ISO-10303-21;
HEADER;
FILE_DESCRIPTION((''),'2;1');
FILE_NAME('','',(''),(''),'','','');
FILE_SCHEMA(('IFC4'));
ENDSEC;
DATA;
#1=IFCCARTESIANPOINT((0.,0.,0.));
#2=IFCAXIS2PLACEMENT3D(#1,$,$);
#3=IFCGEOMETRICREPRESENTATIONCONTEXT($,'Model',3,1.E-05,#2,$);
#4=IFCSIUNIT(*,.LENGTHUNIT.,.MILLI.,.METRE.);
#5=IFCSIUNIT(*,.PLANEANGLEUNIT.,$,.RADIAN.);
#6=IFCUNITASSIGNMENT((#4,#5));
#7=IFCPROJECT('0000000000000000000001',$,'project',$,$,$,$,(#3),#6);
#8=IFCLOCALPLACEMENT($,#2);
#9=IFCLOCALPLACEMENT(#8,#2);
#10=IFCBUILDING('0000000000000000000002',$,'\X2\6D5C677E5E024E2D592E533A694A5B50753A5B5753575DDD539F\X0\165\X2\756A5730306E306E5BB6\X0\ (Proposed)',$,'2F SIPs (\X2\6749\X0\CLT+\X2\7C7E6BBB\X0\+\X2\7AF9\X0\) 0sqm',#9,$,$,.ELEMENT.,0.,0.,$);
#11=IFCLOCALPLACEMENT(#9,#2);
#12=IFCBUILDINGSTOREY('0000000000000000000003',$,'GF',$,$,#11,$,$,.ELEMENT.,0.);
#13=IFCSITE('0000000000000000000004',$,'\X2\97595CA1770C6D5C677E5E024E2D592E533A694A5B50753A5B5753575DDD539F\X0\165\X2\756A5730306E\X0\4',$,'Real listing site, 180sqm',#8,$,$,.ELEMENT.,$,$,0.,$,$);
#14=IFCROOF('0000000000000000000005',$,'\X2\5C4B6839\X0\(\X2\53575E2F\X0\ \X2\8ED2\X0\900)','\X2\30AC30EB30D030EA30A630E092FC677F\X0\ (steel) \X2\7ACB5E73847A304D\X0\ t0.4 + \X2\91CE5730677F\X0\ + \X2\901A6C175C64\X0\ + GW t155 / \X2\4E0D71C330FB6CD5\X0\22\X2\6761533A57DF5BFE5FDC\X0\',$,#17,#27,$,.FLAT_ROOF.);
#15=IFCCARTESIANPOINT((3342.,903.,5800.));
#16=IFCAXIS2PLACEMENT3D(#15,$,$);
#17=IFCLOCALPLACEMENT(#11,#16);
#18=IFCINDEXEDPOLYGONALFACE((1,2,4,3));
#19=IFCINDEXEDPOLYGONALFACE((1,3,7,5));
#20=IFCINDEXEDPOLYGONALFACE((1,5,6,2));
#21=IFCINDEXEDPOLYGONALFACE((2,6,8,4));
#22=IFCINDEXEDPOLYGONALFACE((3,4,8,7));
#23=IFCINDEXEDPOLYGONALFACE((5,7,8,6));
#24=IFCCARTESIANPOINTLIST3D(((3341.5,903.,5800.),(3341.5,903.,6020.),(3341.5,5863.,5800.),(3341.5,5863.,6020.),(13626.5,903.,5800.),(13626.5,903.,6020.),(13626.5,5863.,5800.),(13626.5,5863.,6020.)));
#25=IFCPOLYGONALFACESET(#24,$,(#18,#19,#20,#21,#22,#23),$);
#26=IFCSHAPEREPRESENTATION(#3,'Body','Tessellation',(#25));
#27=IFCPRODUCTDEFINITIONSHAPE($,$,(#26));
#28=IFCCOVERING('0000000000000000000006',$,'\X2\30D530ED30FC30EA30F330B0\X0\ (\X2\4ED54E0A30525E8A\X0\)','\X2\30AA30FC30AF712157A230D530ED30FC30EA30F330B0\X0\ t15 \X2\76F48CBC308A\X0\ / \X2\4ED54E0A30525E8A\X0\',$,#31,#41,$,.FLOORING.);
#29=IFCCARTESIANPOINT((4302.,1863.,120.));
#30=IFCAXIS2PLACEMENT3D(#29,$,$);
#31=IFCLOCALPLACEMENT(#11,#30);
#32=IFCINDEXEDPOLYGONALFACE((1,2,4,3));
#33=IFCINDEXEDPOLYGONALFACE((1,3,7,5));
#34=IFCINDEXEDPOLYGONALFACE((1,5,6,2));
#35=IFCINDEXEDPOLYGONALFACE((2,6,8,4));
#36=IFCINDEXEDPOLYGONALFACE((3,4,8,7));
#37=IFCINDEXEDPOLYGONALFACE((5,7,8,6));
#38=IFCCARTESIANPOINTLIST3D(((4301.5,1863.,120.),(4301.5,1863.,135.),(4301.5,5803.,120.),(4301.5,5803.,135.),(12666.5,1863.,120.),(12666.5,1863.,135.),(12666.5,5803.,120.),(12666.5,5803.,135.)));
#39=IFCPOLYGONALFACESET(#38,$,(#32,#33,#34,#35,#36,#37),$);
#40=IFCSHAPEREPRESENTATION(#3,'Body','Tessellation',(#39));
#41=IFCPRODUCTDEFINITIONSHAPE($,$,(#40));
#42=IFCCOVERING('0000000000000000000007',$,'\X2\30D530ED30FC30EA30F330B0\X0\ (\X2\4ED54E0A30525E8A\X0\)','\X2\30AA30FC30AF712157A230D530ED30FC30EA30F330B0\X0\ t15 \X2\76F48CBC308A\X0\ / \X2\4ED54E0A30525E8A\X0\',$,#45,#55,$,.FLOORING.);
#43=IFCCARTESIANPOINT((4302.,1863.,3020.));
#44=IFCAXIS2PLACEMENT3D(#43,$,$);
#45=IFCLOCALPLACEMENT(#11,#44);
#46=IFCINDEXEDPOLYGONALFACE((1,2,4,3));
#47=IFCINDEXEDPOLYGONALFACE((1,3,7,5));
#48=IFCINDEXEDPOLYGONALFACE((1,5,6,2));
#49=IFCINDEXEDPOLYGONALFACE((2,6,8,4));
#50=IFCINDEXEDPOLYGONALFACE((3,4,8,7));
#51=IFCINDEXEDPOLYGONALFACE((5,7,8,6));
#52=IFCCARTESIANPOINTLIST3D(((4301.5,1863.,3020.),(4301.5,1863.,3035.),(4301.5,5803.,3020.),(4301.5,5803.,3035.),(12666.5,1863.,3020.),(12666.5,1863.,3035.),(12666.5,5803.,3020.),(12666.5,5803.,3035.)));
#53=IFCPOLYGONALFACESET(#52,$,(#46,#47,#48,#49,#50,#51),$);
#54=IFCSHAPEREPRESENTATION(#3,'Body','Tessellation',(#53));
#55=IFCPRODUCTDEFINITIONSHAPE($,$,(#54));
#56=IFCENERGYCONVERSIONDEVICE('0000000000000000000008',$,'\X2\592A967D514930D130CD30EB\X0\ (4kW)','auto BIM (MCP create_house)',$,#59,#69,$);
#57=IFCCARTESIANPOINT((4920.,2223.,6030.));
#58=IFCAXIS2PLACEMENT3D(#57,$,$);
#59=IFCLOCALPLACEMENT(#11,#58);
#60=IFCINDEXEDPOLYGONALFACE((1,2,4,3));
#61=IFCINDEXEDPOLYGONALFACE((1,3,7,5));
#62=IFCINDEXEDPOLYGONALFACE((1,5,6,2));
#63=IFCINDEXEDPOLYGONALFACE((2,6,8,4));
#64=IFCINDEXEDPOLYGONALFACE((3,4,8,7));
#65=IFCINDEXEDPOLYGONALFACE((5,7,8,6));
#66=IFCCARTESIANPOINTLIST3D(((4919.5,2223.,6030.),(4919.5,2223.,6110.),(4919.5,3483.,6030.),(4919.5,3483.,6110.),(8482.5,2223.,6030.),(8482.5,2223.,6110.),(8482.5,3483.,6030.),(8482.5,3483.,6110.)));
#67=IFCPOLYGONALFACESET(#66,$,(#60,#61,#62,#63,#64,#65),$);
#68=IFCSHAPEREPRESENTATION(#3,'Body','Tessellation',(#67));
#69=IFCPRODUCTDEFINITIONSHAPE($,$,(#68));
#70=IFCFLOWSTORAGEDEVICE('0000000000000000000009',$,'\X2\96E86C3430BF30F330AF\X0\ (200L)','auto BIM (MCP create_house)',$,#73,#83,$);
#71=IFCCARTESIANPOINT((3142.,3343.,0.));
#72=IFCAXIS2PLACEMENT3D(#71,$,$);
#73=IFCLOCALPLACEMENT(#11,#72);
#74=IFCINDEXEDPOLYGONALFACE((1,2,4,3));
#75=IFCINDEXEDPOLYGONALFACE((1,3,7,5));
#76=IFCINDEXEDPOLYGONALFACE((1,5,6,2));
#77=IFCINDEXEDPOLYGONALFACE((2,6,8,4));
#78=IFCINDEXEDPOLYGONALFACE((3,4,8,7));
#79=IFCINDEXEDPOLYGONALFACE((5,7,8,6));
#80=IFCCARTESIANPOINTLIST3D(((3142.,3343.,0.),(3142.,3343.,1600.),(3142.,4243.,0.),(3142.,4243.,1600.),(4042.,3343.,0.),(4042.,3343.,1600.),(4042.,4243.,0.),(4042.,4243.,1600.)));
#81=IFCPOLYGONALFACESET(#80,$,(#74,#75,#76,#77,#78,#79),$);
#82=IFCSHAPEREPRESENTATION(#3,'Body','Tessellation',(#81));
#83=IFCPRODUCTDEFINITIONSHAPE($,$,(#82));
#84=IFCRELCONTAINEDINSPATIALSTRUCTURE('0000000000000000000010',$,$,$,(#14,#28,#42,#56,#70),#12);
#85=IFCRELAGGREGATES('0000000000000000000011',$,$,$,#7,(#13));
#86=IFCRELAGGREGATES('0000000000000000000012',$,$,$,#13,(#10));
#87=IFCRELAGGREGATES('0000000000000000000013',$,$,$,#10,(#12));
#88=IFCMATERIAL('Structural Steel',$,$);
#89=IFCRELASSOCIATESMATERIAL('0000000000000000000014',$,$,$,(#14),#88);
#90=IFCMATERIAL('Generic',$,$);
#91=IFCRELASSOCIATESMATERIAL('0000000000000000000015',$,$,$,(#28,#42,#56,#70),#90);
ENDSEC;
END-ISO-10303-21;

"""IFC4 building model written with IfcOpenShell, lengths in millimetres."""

from ifc_helpers import new_model, si_unit, frame, frame_2d, origin, place, context, project, spatial, rectangle, extrude, material, element, save


model = new_model("IFC4")

# Units and contexts
model_context = context("Model", 3, precision=1e-05, world=origin())
ifc_project = project(units=[si_unit("LENGTHUNIT", "METRE", prefix="MILLI"), si_unit("PLANEANGLEUNIT", "RADIAN")], contexts=[model_context])

# Site, building, storey
site_placement = place(None, origin())
site = spatial("IfcSite", under=ifc_project, at=site_placement, Name="静岡県浜松市中央区楊子町字南川原165番地の4", ObjectType="Real listing site, 180sqm", CompositionType="ELEMENT", RefElevation=0.0)
building_placement = place(site_placement, origin())
building = spatial("IfcBuilding", under=site, at=building_placement, Name="浜松市中央区楊子町字南川原165番地のの家 (Proposed)", ObjectType="2F SIPs (杉CLT+籾殻+竹) 0sqm", CompositionType="ELEMENT", ElevationOfRefHeight=0.0, ElevationOfTerrain=0.0)
storey_placement = place(building_placement, origin())
storey = spatial("IfcBuildingStorey", under=building, at=storey_placement, Name="GF", CompositionType="ELEMENT", Elevation=0.0)

# Roof
ifc_material_1 = material(Name="Structural Steel")
for number, where, name in (
    (1, (3342.0, 903.0, 5800.0), "屋根(南帯 軒900)"),
):
    element("IfcRoof", number, at=place(storey_placement, frame(where)), inside=storey, material=ifc_material_1, Name=name, Description="ガルバリウム鋼板 (steel) 立平葺き t0.4 + 野地板 + 通気層 + GW t155 / 不燃・法22条区域対応", PredefinedType="FLAT_ROOF", context=model_context, shape_type="SweptSolid", body=[
        extrude(rectangle(XDim=10285.0, YDim=4960.0, at=frame_2d((5142.0, 2480.0))), frame((3342.0, 903.0, 5800.0)), (0.0, 0.0, 1.0), 220.0),
    ])

# Coverings
ifc_material_2 = material(Name="Generic")
covering_1_placement = place(storey_placement, frame((4302.0, 1863.0, 120.0)))
element("IfcCovering", 2, at=covering_1_placement, inside=storey, material=ifc_material_2, Name="フローリング (仕上げ床)", Description="オーク無垢フローリング t15 直貼り / 仕上げ床", PredefinedType="FLOORING", context=model_context, shape_type="SweptSolid", body=[
    extrude(rectangle(XDim=8365.0, YDim=3940.0, at=frame_2d((4182.0, 1970.0))), frame((4302.0, 1863.0, 120.0)), (0.0, 0.0, 1.0), 15.0),
])
covering_2_placement = place(storey_placement, frame((4302.0, 1863.0, 3020.0)))
element("IfcCovering", 3, at=covering_2_placement, inside=storey, material=ifc_material_2, Name="フローリング (仕上げ床)", Description="オーク無垢フローリング t15 直貼り / 仕上げ床", PredefinedType="FLOORING", context=model_context, shape_type="SweptSolid", body=[
    extrude(rectangle(XDim=8365.0, YDim=3940.0, at=frame_2d((4182.0, 1970.0))), frame((4302.0, 1863.0, 3020.0)), (0.0, 0.0, 1.0), 15.0),
])

# Energy conversion device
energy_conversion_device_placement = place(storey_placement, frame((4920.0, 2223.0, 6030.0)))
element("IfcEnergyConversionDevice", 4, at=energy_conversion_device_placement, inside=storey, material=ifc_material_2, Name="太陽光パネル (4kW)", Description="auto BIM (MCP create_house)", context=model_context, shape_type="SweptSolid", body=[
    extrude(rectangle(XDim=3563.0, YDim=1260.0, at=frame_2d((1781.0, 630.0))), frame((4920.0, 2223.0, 6030.0)), (0.0, 0.0, 1.0), 80.0),
])

# Flow storage device
flow_storage_device_placement = place(storey_placement, frame((3142.0, 3343.0, 0.0)))
element("IfcFlowStorageDevice", 5, at=flow_storage_device_placement, inside=storey, material=ifc_material_2, Name="雨水タンク (200L)", Description="auto BIM (MCP create_house)", context=model_context, shape_type="SweptSolid", body=[
    extrude(rectangle(XDim=900.0, YDim=900.0, at=frame_2d((450.0, 450.0))), frame((3142.0, 3343.0, 0.0)), (0.0, 0.0, 1.0), 1600.0),
])

save(model, "model.ifc")
